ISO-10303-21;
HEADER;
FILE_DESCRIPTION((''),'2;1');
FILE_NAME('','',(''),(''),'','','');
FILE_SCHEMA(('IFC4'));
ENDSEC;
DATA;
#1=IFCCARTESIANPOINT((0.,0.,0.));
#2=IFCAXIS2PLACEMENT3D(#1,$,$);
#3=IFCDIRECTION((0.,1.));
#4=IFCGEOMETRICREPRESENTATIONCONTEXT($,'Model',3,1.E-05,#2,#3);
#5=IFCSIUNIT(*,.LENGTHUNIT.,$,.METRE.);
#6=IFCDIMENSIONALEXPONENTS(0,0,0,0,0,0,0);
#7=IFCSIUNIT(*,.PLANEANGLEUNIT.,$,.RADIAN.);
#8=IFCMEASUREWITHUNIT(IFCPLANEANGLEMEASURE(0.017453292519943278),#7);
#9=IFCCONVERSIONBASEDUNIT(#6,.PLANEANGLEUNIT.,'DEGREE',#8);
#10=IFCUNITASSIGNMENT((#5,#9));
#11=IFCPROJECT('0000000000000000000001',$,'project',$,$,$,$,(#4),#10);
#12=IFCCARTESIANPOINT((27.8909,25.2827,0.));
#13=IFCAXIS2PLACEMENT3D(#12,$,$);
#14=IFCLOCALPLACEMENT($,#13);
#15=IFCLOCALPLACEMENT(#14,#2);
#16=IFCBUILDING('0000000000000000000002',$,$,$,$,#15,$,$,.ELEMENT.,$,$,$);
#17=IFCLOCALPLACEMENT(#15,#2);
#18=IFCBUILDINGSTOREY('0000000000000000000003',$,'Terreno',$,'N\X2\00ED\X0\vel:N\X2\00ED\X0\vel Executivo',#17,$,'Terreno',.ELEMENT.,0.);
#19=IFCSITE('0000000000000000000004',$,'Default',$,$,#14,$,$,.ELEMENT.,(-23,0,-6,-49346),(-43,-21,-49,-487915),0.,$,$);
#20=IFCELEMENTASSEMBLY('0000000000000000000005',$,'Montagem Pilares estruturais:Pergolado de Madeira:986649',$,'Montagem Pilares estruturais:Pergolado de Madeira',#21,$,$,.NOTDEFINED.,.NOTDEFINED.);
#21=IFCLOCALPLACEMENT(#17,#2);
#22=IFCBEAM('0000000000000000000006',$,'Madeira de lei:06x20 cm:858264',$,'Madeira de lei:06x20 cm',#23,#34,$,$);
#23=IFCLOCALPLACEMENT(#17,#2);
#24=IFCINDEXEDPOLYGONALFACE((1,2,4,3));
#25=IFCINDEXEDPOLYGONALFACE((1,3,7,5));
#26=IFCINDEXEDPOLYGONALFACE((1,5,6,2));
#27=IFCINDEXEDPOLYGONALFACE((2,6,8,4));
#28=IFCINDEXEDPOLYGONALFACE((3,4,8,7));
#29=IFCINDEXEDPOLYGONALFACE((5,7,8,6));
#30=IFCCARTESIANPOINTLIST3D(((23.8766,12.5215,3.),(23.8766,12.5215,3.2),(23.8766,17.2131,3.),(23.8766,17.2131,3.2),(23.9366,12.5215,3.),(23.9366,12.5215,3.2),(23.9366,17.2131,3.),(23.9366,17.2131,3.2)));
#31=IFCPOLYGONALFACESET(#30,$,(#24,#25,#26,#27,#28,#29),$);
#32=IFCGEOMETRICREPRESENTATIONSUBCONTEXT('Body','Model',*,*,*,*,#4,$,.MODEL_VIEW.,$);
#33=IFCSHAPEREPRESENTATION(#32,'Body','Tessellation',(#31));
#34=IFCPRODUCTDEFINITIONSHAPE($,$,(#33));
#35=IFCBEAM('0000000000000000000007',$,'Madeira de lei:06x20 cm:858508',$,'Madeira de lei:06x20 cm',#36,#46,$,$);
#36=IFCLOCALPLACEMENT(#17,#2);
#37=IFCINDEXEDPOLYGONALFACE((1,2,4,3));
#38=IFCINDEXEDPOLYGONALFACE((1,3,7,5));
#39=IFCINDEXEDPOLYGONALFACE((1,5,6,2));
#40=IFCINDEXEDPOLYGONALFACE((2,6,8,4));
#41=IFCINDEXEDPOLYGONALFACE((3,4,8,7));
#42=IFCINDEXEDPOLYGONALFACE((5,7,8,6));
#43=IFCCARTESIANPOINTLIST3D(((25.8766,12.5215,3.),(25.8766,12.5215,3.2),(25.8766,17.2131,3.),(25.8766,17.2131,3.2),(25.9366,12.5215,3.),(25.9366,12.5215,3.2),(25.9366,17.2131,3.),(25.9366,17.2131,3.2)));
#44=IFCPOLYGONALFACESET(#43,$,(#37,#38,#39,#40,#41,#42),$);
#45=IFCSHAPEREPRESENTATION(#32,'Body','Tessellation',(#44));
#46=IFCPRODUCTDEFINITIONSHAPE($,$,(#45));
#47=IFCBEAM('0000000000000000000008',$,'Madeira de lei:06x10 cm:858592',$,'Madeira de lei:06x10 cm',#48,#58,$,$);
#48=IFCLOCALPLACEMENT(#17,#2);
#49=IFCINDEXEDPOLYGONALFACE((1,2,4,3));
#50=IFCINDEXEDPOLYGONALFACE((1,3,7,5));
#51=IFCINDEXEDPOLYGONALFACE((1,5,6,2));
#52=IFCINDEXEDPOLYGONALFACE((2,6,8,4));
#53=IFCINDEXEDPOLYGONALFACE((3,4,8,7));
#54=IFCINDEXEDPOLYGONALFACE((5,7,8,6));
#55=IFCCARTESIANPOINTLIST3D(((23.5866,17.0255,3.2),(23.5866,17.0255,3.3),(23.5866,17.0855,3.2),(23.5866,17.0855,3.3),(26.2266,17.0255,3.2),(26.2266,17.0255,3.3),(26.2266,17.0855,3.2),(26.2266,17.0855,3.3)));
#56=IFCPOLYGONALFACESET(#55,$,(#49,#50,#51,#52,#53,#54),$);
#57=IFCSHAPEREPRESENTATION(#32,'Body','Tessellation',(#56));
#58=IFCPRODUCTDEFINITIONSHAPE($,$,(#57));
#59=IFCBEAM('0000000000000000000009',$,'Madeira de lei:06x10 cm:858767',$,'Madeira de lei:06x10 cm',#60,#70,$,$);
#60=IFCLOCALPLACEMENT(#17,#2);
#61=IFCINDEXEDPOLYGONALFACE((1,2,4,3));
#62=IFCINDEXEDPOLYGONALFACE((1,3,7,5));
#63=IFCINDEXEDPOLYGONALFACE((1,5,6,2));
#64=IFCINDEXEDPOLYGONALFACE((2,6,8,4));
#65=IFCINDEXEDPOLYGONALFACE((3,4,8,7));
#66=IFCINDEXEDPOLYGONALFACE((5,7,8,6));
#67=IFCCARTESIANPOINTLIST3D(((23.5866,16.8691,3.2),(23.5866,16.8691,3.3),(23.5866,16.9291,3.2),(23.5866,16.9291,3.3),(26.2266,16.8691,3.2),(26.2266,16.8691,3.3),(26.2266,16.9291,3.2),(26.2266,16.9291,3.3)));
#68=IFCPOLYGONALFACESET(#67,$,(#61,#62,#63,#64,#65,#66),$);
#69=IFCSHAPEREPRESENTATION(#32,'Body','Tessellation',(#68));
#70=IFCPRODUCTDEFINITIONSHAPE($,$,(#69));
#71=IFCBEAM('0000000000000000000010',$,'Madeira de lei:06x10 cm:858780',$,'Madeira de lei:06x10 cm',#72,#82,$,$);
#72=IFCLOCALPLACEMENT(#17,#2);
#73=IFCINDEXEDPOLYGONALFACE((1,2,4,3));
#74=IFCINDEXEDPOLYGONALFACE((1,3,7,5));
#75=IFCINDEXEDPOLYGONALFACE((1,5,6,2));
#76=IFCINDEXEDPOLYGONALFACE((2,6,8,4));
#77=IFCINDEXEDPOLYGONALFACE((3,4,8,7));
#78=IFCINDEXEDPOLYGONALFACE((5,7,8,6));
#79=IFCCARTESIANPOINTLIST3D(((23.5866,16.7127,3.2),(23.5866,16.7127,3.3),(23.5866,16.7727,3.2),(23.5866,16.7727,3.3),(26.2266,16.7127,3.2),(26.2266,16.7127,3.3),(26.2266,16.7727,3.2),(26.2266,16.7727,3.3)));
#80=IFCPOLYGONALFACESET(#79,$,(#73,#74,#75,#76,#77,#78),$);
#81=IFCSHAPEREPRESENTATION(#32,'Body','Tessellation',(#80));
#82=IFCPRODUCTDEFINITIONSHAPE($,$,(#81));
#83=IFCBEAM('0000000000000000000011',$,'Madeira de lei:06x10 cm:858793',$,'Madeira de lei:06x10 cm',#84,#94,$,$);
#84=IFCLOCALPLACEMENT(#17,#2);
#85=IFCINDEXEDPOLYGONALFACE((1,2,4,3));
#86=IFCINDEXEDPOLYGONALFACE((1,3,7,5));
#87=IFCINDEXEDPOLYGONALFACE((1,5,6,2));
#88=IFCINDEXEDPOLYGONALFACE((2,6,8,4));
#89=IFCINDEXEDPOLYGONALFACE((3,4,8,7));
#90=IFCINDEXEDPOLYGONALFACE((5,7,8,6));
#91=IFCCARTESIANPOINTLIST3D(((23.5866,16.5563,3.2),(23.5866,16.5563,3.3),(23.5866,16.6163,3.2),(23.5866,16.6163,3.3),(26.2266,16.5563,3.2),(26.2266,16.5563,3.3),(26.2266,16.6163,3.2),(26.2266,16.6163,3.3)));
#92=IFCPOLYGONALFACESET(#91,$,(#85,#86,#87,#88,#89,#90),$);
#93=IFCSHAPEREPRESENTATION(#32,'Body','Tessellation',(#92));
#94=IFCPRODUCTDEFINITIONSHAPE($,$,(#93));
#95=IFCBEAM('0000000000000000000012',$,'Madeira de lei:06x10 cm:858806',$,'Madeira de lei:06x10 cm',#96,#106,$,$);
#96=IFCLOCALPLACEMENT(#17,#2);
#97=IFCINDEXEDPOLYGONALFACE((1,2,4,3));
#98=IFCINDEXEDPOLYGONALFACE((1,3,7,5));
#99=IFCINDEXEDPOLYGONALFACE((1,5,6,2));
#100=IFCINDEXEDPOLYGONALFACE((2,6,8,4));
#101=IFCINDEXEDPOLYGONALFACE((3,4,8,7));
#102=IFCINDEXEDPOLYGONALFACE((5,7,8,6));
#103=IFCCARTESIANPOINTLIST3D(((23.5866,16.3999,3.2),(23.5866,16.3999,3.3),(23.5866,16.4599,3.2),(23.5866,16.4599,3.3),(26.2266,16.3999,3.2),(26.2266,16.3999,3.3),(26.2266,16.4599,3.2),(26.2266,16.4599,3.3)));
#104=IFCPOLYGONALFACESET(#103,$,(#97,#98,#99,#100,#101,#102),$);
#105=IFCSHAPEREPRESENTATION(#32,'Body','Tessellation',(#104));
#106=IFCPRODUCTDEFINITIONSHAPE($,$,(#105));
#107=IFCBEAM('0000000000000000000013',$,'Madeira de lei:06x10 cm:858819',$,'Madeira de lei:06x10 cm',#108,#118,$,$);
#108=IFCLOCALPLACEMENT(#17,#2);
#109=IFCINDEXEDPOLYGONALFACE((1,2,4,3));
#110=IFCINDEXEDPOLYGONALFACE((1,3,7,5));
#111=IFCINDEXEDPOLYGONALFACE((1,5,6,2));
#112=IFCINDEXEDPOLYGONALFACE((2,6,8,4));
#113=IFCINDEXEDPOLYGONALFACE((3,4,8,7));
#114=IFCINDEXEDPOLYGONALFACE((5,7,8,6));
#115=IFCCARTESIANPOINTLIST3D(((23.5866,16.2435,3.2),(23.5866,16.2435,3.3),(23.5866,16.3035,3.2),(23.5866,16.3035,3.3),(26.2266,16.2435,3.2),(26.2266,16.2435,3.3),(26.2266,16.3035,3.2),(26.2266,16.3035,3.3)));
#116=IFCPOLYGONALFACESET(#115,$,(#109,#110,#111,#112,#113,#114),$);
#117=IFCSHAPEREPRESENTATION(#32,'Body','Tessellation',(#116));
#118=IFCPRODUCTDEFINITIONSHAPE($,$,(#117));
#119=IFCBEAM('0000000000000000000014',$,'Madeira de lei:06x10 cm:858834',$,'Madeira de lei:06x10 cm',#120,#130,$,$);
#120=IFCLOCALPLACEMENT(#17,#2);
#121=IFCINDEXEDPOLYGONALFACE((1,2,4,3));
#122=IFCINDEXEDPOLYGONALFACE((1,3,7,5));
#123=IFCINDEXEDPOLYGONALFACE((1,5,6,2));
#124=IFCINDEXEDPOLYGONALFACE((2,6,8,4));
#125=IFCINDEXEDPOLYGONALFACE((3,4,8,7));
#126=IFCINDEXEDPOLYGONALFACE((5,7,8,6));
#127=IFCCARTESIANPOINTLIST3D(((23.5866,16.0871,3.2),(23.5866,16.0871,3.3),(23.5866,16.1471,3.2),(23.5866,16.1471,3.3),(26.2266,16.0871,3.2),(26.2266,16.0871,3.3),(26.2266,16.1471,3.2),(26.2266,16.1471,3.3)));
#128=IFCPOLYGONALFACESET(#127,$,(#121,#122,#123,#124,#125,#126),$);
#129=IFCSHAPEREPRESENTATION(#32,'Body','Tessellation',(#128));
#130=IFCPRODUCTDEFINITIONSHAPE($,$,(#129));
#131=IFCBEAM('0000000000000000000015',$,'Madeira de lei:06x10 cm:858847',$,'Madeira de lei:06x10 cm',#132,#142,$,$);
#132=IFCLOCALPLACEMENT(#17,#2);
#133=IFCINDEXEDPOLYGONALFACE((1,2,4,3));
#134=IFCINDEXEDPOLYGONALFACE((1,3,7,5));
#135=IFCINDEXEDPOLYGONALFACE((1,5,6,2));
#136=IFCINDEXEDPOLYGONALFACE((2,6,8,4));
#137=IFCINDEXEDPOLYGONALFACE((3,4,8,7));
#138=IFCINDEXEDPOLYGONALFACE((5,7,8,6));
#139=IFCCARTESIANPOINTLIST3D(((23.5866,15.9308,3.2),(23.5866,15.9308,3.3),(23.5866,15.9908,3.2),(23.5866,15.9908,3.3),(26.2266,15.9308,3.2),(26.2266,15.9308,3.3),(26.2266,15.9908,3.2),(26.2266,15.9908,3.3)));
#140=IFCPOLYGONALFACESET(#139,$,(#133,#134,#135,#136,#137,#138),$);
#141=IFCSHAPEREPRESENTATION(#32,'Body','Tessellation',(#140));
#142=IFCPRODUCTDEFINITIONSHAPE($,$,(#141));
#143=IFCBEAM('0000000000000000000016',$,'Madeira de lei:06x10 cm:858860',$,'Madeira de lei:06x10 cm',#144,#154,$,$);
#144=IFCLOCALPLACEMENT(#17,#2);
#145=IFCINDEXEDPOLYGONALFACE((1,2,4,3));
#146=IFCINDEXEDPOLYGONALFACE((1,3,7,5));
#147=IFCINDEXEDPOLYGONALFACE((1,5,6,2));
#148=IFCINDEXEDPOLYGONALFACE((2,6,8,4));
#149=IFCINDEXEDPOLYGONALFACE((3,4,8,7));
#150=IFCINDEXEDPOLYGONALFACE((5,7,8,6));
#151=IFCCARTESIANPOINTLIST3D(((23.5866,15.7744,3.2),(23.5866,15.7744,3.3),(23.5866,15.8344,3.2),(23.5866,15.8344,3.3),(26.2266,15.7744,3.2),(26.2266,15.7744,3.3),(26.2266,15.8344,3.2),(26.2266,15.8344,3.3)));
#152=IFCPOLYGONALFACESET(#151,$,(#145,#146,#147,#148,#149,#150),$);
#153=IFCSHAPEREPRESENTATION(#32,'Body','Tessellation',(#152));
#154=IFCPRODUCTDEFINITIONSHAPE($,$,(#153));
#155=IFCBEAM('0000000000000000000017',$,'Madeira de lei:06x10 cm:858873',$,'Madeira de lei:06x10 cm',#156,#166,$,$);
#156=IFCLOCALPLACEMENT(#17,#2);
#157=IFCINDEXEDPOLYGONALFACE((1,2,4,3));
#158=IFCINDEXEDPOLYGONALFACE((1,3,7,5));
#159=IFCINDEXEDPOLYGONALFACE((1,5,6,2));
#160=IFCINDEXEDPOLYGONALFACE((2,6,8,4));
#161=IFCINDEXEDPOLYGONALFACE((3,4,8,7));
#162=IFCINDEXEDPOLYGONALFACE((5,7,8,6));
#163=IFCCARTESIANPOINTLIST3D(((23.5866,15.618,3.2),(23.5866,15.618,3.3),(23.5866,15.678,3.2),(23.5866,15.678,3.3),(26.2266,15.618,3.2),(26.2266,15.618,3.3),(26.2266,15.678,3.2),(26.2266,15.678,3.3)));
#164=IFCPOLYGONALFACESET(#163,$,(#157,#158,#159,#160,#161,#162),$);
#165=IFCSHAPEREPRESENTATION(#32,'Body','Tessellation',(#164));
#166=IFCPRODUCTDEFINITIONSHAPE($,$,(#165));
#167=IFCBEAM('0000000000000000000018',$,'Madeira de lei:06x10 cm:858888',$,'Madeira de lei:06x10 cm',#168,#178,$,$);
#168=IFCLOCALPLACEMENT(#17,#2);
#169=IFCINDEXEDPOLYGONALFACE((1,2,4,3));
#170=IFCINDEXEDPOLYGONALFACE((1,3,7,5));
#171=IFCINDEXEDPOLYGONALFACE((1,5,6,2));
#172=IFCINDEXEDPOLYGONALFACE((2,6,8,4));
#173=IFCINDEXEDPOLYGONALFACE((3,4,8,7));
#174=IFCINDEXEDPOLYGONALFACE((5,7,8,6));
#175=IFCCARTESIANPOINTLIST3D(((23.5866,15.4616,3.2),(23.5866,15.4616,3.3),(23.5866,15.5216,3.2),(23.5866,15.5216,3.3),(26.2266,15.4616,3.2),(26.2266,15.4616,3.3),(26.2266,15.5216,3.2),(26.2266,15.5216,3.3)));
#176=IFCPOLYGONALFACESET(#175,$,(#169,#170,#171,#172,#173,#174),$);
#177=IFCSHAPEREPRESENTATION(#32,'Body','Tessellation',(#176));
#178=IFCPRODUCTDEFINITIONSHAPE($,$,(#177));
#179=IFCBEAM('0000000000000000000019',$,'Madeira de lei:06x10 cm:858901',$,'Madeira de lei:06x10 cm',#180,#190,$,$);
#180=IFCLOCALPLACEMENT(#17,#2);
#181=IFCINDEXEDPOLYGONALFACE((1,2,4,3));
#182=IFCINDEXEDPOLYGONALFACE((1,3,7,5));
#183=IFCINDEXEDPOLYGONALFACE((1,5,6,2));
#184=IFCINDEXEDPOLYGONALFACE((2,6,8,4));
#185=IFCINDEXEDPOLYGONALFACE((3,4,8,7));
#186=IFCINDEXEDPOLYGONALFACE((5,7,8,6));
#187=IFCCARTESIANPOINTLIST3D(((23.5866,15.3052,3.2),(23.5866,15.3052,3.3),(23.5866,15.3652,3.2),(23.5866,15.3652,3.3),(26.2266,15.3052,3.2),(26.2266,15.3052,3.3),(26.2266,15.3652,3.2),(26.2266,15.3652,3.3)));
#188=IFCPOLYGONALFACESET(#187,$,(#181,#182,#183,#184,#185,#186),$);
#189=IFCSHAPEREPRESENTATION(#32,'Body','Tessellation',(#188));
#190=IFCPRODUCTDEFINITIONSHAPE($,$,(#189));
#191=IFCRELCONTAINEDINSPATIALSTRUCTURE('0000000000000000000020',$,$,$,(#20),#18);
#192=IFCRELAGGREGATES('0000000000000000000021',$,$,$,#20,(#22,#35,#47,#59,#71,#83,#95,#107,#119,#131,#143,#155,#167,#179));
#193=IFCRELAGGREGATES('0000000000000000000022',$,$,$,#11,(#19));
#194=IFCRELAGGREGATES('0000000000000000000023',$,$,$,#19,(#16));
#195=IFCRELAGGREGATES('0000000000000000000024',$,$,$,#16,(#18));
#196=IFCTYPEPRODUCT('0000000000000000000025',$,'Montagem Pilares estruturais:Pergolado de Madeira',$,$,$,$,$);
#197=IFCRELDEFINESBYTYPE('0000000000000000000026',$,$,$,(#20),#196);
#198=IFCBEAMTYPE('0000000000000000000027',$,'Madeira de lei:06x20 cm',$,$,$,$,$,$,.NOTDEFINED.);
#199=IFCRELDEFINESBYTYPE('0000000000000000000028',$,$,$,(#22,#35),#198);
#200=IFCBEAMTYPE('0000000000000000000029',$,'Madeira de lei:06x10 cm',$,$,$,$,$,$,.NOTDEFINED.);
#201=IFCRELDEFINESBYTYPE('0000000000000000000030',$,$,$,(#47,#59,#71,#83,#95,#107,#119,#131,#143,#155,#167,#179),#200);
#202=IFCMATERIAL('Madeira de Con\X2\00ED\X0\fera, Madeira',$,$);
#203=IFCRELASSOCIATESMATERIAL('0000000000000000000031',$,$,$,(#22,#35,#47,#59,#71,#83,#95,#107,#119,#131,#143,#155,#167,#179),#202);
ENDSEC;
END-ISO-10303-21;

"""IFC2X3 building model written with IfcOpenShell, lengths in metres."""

from ifc_helpers import new_model, entity, si_unit, converted_unit, direction, frame, frame_2d, origin, origin_2d_with_axis, place, context, subcontext, project, spatial, rectangle, extrude, material, type_object, element, aggregate, save


model = new_model("IFC2X3")

# Units and contexts
model_context = context("Model", 3, precision=1e-05, world=origin(), true_north=direction((0.0, 1.0)))
body_context = subcontext(model_context, "Body", "Model", "MODEL_VIEW")
ifc_project = project(units=[si_unit("LENGTHUNIT", "METRE"), converted_unit("PLANEANGLEUNIT", "DEGREE", entity("IfcPlaneAngleMeasure", 0.017453292519943278), si_unit("PLANEANGLEUNIT", "RADIAN"), dimensions=[0, 0, 0, 0, 0, 0, 0])], contexts=[model_context])

# Site, building, storey
site_placement = place(None, frame((27.8909, 25.2827, 0.0)))
site = spatial("IfcSite", under=ifc_project, at=site_placement, Name="Default", CompositionType="ELEMENT", RefLatitude=(-23, 0, -6, -49346), RefLongitude=(-43, -21, -49, -487915), RefElevation=0.0)
building_placement = place(site_placement, origin())
building = spatial("IfcBuilding", under=site, at=building_placement, CompositionType="ELEMENT")
storey_placement = place(building_placement, origin())
storey = spatial("IfcBuildingStorey", under=building, at=storey_placement, Name="Terreno", ObjectType="Nível:Nível Executivo", LongName="Terreno", CompositionType="ELEMENT", Elevation=0.0)

# Element assembly, beams
type_product = type_object("IfcTypeProduct", Name="Montagem Pilares estruturais:Pergolado de Madeira")
assembly_placement = place(storey_placement, origin())
assembly = element("IfcElementAssembly", 1, at=assembly_placement, inside=storey, type_object=type_product, Name="Montagem Pilares estruturais:Pergolado de Madeira:986649", ObjectType="Montagem Pilares estruturais:Pergolado de Madeira", AssemblyPlace="NOTDEFINED", PredefinedType="NOTDEFINED")
ifc_material_1 = material(Name="Madeira de Conífera, Madeira")
beam_type_1 = type_object("IfcBeamType", Name="Madeira de lei:06x20 cm", PredefinedType="NOTDEFINED")
beam_1_placement = place(assembly_placement, frame((23.9066, 17.2131, 3.1), z_axis=(0.0, 0.0, 1.0), x_axis=(0.0, -1.0, 0.0)))
beam_1 = element("IfcBeam", 2, at=beam_1_placement, type_object=beam_type_1, material=ifc_material_1, Name="Madeira de lei:06x20 cm:858264", ObjectType="Madeira de lei:06x20 cm", context=body_context, shape_type="SweptSolid", body=[
    extrude(rectangle(XDim=0.2, YDim=0.06, at=origin_2d_with_axis()), frame((0.0, 0.0, 0.0), z_axis=(1.0, 0.0, 0.0), x_axis=(0.0, 0.0, -1.0)), (0.0, 0.0, 1.0), 4.6916),
])
beam_2_placement = place(assembly_placement, frame((25.9066, 17.2131, 3.1), z_axis=(0.0, 0.0, 1.0), x_axis=(0.0, -1.0, 0.0)))
beam_2 = element("IfcBeam", 3, at=beam_2_placement, type_object=beam_type_1, material=ifc_material_1, Name="Madeira de lei:06x20 cm:858508", ObjectType="Madeira de lei:06x20 cm", context=body_context, shape_type="SweptSolid", body=[
    extrude(rectangle(XDim=0.2, YDim=0.06, at=origin_2d_with_axis()), frame((0.0, 0.0, 0.0), z_axis=(1.0, 0.0, 0.0), x_axis=(0.0, 0.0, -1.0)), (0.0, 0.0, 1.0), 4.6916),
])
beam_type_2 = type_object("IfcBeamType", Name="Madeira de lei:06x10 cm", PredefinedType="NOTDEFINED")
beam_3_placement = place(assembly_placement, frame((23.5866, 17.0555, 3.2)))
beam_3 = element("IfcBeam", 4, at=beam_3_placement, type_object=beam_type_2, material=ifc_material_1, Name="Madeira de lei:06x10 cm:858592", ObjectType="Madeira de lei:06x10 cm", context=body_context, shape_type="SweptSolid", body=[
    extrude(rectangle(XDim=0.1, YDim=0.06, at=frame_2d((0.0, 0.0), x_axis=(1.0, 0.0))), frame((0.0, 0.0, 0.05), z_axis=(1.0, 0.0, 0.0), x_axis=(0.0, 0.0, -1.0)), (0.0, 0.0, 1.0), 2.64),
])
beam_4_placement = place(assembly_placement, frame((23.5866, 16.8991, 3.2)))
beam_4 = element("IfcBeam", 5, at=beam_4_placement, type_object=beam_type_2, material=ifc_material_1, Name="Madeira de lei:06x10 cm:858767", ObjectType="Madeira de lei:06x10 cm", context=body_context, shape_type="SweptSolid", body=[
    extrude(rectangle(XDim=0.1, YDim=0.06, at=frame_2d((0.0, 0.0), x_axis=(1.0, 0.0))), frame((0.0, 0.0, 0.05), z_axis=(1.0, 0.0, 0.0), x_axis=(0.0, 0.0, -1.0)), (0.0, 0.0, 1.0), 2.64),
])
beam_5_placement = place(assembly_placement, frame((23.5866, 16.7427, 3.2)))
beam_5 = element("IfcBeam", 6, at=beam_5_placement, type_object=beam_type_2, material=ifc_material_1, Name="Madeira de lei:06x10 cm:858780", ObjectType="Madeira de lei:06x10 cm", context=body_context, shape_type="SweptSolid", body=[
    extrude(rectangle(XDim=0.1, YDim=0.06, at=frame_2d((0.0, 0.0), x_axis=(1.0, 0.0))), frame((0.0, 0.0, 0.05), z_axis=(1.0, 0.0, 0.0), x_axis=(0.0, 0.0, -1.0)), (0.0, 0.0, 1.0), 2.64),
])
beam_6_placement = place(assembly_placement, frame((23.5866, 16.5863, 3.2)))
beam_6 = element("IfcBeam", 7, at=beam_6_placement, type_object=beam_type_2, material=ifc_material_1, Name="Madeira de lei:06x10 cm:858793", ObjectType="Madeira de lei:06x10 cm", context=body_context, shape_type="SweptSolid", body=[
    extrude(rectangle(XDim=0.1, YDim=0.06, at=frame_2d((0.0, 0.0), x_axis=(1.0, 0.0))), frame((0.0, 0.0, 0.05), z_axis=(1.0, 0.0, 0.0), x_axis=(0.0, 0.0, -1.0)), (0.0, 0.0, 1.0), 2.64),
])
beam_7_placement = place(assembly_placement, frame((23.5866, 16.4299, 3.2)))
beam_7 = element("IfcBeam", 8, at=beam_7_placement, type_object=beam_type_2, material=ifc_material_1, Name="Madeira de lei:06x10 cm:858806", ObjectType="Madeira de lei:06x10 cm", context=body_context, shape_type="SweptSolid", body=[
    extrude(rectangle(XDim=0.1, YDim=0.06, at=frame_2d((0.0, 0.0), x_axis=(1.0, 0.0))), frame((0.0, 0.0, 0.05), z_axis=(1.0, 0.0, 0.0), x_axis=(0.0, 0.0, -1.0)), (0.0, 0.0, 1.0), 2.64),
])
beam_8_placement = place(assembly_placement, frame((23.5866, 16.2735, 3.2)))
beam_8 = element("IfcBeam", 9, at=beam_8_placement, type_object=beam_type_2, material=ifc_material_1, Name="Madeira de lei:06x10 cm:858819", ObjectType="Madeira de lei:06x10 cm", context=body_context, shape_type="SweptSolid", body=[
    extrude(rectangle(XDim=0.1, YDim=0.06, at=frame_2d((0.0, 0.0), x_axis=(1.0, 0.0))), frame((0.0, 0.0, 0.05), z_axis=(1.0, 0.0, 0.0), x_axis=(0.0, 0.0, -1.0)), (0.0, 0.0, 1.0), 2.64),
])
beam_9_placement = place(assembly_placement, frame((23.5866, 16.1171, 3.2)))
beam_9 = element("IfcBeam", 10, at=beam_9_placement, type_object=beam_type_2, material=ifc_material_1, Name="Madeira de lei:06x10 cm:858834", ObjectType="Madeira de lei:06x10 cm", context=body_context, shape_type="SweptSolid", body=[
    extrude(rectangle(XDim=0.1, YDim=0.06, at=frame_2d((0.0, 0.0), x_axis=(1.0, 0.0))), frame((0.0, 0.0, 0.05), z_axis=(1.0, 0.0, 0.0), x_axis=(0.0, 0.0, -1.0)), (0.0, 0.0, 1.0), 2.64),
])
beam_10_placement = place(assembly_placement, frame((23.5866, 15.9608, 3.2)))
beam_10 = element("IfcBeam", 11, at=beam_10_placement, type_object=beam_type_2, material=ifc_material_1, Name="Madeira de lei:06x10 cm:858847", ObjectType="Madeira de lei:06x10 cm", context=body_context, shape_type="SweptSolid", body=[
    extrude(rectangle(XDim=0.1, YDim=0.06, at=frame_2d((0.0, 0.0), x_axis=(1.0, 0.0))), frame((0.0, 0.0, 0.05), z_axis=(1.0, 0.0, 0.0), x_axis=(0.0, 0.0, -1.0)), (0.0, 0.0, 1.0), 2.64),
])
beam_11_placement = place(assembly_placement, frame((23.5866, 15.8044, 3.2)))
beam_11 = element("IfcBeam", 12, at=beam_11_placement, type_object=beam_type_2, material=ifc_material_1, Name="Madeira de lei:06x10 cm:858860", ObjectType="Madeira de lei:06x10 cm", context=body_context, shape_type="SweptSolid", body=[
    extrude(rectangle(XDim=0.1, YDim=0.06, at=frame_2d((0.0, 0.0), x_axis=(1.0, 0.0))), frame((0.0, 0.0, 0.05), z_axis=(1.0, 0.0, 0.0), x_axis=(0.0, 0.0, -1.0)), (0.0, 0.0, 1.0), 2.64),
])
beam_12_placement = place(assembly_placement, frame((23.5866, 15.648, 3.2)))
beam_12 = element("IfcBeam", 13, at=beam_12_placement, type_object=beam_type_2, material=ifc_material_1, Name="Madeira de lei:06x10 cm:858873", ObjectType="Madeira de lei:06x10 cm", context=body_context, shape_type="SweptSolid", body=[
    extrude(rectangle(XDim=0.1, YDim=0.06, at=frame_2d((0.0, 0.0), x_axis=(1.0, 0.0))), frame((0.0, 0.0, 0.05), z_axis=(1.0, 0.0, 0.0), x_axis=(0.0, 0.0, -1.0)), (0.0, 0.0, 1.0), 2.64),
])
beam_13_placement = place(assembly_placement, frame((23.5866, 15.4916, 3.2)))
beam_13 = element("IfcBeam", 14, at=beam_13_placement, type_object=beam_type_2, material=ifc_material_1, Name="Madeira de lei:06x10 cm:858888", ObjectType="Madeira de lei:06x10 cm", context=body_context, shape_type="SweptSolid", body=[
    extrude(rectangle(XDim=0.1, YDim=0.06, at=frame_2d((0.0, 0.0), x_axis=(1.0, 0.0))), frame((0.0, 0.0, 0.05), z_axis=(1.0, 0.0, 0.0), x_axis=(0.0, 0.0, -1.0)), (0.0, 0.0, 1.0), 2.64),
])
beam_14_placement = place(assembly_placement, frame((23.5866, 15.3352, 3.2)))
beam_14 = element("IfcBeam", 15, at=beam_14_placement, type_object=beam_type_2, material=ifc_material_1, Name="Madeira de lei:06x10 cm:858901", ObjectType="Madeira de lei:06x10 cm", context=body_context, shape_type="SweptSolid", body=[
    extrude(rectangle(XDim=0.1, YDim=0.06, at=frame_2d((0.0, 0.0), x_axis=(1.0, 0.0))), frame((0.0, 0.0, 0.05), z_axis=(1.0, 0.0, 0.0), x_axis=(0.0, 0.0, -1.0)), (0.0, 0.0, 1.0), 2.64),
])
aggregate(assembly, [beam_1, beam_2, beam_3, beam_4, beam_5, beam_6, beam_7, beam_8, beam_9, beam_10, beam_11, beam_12, beam_13, beam_14])

save(model, "model.ifc")
